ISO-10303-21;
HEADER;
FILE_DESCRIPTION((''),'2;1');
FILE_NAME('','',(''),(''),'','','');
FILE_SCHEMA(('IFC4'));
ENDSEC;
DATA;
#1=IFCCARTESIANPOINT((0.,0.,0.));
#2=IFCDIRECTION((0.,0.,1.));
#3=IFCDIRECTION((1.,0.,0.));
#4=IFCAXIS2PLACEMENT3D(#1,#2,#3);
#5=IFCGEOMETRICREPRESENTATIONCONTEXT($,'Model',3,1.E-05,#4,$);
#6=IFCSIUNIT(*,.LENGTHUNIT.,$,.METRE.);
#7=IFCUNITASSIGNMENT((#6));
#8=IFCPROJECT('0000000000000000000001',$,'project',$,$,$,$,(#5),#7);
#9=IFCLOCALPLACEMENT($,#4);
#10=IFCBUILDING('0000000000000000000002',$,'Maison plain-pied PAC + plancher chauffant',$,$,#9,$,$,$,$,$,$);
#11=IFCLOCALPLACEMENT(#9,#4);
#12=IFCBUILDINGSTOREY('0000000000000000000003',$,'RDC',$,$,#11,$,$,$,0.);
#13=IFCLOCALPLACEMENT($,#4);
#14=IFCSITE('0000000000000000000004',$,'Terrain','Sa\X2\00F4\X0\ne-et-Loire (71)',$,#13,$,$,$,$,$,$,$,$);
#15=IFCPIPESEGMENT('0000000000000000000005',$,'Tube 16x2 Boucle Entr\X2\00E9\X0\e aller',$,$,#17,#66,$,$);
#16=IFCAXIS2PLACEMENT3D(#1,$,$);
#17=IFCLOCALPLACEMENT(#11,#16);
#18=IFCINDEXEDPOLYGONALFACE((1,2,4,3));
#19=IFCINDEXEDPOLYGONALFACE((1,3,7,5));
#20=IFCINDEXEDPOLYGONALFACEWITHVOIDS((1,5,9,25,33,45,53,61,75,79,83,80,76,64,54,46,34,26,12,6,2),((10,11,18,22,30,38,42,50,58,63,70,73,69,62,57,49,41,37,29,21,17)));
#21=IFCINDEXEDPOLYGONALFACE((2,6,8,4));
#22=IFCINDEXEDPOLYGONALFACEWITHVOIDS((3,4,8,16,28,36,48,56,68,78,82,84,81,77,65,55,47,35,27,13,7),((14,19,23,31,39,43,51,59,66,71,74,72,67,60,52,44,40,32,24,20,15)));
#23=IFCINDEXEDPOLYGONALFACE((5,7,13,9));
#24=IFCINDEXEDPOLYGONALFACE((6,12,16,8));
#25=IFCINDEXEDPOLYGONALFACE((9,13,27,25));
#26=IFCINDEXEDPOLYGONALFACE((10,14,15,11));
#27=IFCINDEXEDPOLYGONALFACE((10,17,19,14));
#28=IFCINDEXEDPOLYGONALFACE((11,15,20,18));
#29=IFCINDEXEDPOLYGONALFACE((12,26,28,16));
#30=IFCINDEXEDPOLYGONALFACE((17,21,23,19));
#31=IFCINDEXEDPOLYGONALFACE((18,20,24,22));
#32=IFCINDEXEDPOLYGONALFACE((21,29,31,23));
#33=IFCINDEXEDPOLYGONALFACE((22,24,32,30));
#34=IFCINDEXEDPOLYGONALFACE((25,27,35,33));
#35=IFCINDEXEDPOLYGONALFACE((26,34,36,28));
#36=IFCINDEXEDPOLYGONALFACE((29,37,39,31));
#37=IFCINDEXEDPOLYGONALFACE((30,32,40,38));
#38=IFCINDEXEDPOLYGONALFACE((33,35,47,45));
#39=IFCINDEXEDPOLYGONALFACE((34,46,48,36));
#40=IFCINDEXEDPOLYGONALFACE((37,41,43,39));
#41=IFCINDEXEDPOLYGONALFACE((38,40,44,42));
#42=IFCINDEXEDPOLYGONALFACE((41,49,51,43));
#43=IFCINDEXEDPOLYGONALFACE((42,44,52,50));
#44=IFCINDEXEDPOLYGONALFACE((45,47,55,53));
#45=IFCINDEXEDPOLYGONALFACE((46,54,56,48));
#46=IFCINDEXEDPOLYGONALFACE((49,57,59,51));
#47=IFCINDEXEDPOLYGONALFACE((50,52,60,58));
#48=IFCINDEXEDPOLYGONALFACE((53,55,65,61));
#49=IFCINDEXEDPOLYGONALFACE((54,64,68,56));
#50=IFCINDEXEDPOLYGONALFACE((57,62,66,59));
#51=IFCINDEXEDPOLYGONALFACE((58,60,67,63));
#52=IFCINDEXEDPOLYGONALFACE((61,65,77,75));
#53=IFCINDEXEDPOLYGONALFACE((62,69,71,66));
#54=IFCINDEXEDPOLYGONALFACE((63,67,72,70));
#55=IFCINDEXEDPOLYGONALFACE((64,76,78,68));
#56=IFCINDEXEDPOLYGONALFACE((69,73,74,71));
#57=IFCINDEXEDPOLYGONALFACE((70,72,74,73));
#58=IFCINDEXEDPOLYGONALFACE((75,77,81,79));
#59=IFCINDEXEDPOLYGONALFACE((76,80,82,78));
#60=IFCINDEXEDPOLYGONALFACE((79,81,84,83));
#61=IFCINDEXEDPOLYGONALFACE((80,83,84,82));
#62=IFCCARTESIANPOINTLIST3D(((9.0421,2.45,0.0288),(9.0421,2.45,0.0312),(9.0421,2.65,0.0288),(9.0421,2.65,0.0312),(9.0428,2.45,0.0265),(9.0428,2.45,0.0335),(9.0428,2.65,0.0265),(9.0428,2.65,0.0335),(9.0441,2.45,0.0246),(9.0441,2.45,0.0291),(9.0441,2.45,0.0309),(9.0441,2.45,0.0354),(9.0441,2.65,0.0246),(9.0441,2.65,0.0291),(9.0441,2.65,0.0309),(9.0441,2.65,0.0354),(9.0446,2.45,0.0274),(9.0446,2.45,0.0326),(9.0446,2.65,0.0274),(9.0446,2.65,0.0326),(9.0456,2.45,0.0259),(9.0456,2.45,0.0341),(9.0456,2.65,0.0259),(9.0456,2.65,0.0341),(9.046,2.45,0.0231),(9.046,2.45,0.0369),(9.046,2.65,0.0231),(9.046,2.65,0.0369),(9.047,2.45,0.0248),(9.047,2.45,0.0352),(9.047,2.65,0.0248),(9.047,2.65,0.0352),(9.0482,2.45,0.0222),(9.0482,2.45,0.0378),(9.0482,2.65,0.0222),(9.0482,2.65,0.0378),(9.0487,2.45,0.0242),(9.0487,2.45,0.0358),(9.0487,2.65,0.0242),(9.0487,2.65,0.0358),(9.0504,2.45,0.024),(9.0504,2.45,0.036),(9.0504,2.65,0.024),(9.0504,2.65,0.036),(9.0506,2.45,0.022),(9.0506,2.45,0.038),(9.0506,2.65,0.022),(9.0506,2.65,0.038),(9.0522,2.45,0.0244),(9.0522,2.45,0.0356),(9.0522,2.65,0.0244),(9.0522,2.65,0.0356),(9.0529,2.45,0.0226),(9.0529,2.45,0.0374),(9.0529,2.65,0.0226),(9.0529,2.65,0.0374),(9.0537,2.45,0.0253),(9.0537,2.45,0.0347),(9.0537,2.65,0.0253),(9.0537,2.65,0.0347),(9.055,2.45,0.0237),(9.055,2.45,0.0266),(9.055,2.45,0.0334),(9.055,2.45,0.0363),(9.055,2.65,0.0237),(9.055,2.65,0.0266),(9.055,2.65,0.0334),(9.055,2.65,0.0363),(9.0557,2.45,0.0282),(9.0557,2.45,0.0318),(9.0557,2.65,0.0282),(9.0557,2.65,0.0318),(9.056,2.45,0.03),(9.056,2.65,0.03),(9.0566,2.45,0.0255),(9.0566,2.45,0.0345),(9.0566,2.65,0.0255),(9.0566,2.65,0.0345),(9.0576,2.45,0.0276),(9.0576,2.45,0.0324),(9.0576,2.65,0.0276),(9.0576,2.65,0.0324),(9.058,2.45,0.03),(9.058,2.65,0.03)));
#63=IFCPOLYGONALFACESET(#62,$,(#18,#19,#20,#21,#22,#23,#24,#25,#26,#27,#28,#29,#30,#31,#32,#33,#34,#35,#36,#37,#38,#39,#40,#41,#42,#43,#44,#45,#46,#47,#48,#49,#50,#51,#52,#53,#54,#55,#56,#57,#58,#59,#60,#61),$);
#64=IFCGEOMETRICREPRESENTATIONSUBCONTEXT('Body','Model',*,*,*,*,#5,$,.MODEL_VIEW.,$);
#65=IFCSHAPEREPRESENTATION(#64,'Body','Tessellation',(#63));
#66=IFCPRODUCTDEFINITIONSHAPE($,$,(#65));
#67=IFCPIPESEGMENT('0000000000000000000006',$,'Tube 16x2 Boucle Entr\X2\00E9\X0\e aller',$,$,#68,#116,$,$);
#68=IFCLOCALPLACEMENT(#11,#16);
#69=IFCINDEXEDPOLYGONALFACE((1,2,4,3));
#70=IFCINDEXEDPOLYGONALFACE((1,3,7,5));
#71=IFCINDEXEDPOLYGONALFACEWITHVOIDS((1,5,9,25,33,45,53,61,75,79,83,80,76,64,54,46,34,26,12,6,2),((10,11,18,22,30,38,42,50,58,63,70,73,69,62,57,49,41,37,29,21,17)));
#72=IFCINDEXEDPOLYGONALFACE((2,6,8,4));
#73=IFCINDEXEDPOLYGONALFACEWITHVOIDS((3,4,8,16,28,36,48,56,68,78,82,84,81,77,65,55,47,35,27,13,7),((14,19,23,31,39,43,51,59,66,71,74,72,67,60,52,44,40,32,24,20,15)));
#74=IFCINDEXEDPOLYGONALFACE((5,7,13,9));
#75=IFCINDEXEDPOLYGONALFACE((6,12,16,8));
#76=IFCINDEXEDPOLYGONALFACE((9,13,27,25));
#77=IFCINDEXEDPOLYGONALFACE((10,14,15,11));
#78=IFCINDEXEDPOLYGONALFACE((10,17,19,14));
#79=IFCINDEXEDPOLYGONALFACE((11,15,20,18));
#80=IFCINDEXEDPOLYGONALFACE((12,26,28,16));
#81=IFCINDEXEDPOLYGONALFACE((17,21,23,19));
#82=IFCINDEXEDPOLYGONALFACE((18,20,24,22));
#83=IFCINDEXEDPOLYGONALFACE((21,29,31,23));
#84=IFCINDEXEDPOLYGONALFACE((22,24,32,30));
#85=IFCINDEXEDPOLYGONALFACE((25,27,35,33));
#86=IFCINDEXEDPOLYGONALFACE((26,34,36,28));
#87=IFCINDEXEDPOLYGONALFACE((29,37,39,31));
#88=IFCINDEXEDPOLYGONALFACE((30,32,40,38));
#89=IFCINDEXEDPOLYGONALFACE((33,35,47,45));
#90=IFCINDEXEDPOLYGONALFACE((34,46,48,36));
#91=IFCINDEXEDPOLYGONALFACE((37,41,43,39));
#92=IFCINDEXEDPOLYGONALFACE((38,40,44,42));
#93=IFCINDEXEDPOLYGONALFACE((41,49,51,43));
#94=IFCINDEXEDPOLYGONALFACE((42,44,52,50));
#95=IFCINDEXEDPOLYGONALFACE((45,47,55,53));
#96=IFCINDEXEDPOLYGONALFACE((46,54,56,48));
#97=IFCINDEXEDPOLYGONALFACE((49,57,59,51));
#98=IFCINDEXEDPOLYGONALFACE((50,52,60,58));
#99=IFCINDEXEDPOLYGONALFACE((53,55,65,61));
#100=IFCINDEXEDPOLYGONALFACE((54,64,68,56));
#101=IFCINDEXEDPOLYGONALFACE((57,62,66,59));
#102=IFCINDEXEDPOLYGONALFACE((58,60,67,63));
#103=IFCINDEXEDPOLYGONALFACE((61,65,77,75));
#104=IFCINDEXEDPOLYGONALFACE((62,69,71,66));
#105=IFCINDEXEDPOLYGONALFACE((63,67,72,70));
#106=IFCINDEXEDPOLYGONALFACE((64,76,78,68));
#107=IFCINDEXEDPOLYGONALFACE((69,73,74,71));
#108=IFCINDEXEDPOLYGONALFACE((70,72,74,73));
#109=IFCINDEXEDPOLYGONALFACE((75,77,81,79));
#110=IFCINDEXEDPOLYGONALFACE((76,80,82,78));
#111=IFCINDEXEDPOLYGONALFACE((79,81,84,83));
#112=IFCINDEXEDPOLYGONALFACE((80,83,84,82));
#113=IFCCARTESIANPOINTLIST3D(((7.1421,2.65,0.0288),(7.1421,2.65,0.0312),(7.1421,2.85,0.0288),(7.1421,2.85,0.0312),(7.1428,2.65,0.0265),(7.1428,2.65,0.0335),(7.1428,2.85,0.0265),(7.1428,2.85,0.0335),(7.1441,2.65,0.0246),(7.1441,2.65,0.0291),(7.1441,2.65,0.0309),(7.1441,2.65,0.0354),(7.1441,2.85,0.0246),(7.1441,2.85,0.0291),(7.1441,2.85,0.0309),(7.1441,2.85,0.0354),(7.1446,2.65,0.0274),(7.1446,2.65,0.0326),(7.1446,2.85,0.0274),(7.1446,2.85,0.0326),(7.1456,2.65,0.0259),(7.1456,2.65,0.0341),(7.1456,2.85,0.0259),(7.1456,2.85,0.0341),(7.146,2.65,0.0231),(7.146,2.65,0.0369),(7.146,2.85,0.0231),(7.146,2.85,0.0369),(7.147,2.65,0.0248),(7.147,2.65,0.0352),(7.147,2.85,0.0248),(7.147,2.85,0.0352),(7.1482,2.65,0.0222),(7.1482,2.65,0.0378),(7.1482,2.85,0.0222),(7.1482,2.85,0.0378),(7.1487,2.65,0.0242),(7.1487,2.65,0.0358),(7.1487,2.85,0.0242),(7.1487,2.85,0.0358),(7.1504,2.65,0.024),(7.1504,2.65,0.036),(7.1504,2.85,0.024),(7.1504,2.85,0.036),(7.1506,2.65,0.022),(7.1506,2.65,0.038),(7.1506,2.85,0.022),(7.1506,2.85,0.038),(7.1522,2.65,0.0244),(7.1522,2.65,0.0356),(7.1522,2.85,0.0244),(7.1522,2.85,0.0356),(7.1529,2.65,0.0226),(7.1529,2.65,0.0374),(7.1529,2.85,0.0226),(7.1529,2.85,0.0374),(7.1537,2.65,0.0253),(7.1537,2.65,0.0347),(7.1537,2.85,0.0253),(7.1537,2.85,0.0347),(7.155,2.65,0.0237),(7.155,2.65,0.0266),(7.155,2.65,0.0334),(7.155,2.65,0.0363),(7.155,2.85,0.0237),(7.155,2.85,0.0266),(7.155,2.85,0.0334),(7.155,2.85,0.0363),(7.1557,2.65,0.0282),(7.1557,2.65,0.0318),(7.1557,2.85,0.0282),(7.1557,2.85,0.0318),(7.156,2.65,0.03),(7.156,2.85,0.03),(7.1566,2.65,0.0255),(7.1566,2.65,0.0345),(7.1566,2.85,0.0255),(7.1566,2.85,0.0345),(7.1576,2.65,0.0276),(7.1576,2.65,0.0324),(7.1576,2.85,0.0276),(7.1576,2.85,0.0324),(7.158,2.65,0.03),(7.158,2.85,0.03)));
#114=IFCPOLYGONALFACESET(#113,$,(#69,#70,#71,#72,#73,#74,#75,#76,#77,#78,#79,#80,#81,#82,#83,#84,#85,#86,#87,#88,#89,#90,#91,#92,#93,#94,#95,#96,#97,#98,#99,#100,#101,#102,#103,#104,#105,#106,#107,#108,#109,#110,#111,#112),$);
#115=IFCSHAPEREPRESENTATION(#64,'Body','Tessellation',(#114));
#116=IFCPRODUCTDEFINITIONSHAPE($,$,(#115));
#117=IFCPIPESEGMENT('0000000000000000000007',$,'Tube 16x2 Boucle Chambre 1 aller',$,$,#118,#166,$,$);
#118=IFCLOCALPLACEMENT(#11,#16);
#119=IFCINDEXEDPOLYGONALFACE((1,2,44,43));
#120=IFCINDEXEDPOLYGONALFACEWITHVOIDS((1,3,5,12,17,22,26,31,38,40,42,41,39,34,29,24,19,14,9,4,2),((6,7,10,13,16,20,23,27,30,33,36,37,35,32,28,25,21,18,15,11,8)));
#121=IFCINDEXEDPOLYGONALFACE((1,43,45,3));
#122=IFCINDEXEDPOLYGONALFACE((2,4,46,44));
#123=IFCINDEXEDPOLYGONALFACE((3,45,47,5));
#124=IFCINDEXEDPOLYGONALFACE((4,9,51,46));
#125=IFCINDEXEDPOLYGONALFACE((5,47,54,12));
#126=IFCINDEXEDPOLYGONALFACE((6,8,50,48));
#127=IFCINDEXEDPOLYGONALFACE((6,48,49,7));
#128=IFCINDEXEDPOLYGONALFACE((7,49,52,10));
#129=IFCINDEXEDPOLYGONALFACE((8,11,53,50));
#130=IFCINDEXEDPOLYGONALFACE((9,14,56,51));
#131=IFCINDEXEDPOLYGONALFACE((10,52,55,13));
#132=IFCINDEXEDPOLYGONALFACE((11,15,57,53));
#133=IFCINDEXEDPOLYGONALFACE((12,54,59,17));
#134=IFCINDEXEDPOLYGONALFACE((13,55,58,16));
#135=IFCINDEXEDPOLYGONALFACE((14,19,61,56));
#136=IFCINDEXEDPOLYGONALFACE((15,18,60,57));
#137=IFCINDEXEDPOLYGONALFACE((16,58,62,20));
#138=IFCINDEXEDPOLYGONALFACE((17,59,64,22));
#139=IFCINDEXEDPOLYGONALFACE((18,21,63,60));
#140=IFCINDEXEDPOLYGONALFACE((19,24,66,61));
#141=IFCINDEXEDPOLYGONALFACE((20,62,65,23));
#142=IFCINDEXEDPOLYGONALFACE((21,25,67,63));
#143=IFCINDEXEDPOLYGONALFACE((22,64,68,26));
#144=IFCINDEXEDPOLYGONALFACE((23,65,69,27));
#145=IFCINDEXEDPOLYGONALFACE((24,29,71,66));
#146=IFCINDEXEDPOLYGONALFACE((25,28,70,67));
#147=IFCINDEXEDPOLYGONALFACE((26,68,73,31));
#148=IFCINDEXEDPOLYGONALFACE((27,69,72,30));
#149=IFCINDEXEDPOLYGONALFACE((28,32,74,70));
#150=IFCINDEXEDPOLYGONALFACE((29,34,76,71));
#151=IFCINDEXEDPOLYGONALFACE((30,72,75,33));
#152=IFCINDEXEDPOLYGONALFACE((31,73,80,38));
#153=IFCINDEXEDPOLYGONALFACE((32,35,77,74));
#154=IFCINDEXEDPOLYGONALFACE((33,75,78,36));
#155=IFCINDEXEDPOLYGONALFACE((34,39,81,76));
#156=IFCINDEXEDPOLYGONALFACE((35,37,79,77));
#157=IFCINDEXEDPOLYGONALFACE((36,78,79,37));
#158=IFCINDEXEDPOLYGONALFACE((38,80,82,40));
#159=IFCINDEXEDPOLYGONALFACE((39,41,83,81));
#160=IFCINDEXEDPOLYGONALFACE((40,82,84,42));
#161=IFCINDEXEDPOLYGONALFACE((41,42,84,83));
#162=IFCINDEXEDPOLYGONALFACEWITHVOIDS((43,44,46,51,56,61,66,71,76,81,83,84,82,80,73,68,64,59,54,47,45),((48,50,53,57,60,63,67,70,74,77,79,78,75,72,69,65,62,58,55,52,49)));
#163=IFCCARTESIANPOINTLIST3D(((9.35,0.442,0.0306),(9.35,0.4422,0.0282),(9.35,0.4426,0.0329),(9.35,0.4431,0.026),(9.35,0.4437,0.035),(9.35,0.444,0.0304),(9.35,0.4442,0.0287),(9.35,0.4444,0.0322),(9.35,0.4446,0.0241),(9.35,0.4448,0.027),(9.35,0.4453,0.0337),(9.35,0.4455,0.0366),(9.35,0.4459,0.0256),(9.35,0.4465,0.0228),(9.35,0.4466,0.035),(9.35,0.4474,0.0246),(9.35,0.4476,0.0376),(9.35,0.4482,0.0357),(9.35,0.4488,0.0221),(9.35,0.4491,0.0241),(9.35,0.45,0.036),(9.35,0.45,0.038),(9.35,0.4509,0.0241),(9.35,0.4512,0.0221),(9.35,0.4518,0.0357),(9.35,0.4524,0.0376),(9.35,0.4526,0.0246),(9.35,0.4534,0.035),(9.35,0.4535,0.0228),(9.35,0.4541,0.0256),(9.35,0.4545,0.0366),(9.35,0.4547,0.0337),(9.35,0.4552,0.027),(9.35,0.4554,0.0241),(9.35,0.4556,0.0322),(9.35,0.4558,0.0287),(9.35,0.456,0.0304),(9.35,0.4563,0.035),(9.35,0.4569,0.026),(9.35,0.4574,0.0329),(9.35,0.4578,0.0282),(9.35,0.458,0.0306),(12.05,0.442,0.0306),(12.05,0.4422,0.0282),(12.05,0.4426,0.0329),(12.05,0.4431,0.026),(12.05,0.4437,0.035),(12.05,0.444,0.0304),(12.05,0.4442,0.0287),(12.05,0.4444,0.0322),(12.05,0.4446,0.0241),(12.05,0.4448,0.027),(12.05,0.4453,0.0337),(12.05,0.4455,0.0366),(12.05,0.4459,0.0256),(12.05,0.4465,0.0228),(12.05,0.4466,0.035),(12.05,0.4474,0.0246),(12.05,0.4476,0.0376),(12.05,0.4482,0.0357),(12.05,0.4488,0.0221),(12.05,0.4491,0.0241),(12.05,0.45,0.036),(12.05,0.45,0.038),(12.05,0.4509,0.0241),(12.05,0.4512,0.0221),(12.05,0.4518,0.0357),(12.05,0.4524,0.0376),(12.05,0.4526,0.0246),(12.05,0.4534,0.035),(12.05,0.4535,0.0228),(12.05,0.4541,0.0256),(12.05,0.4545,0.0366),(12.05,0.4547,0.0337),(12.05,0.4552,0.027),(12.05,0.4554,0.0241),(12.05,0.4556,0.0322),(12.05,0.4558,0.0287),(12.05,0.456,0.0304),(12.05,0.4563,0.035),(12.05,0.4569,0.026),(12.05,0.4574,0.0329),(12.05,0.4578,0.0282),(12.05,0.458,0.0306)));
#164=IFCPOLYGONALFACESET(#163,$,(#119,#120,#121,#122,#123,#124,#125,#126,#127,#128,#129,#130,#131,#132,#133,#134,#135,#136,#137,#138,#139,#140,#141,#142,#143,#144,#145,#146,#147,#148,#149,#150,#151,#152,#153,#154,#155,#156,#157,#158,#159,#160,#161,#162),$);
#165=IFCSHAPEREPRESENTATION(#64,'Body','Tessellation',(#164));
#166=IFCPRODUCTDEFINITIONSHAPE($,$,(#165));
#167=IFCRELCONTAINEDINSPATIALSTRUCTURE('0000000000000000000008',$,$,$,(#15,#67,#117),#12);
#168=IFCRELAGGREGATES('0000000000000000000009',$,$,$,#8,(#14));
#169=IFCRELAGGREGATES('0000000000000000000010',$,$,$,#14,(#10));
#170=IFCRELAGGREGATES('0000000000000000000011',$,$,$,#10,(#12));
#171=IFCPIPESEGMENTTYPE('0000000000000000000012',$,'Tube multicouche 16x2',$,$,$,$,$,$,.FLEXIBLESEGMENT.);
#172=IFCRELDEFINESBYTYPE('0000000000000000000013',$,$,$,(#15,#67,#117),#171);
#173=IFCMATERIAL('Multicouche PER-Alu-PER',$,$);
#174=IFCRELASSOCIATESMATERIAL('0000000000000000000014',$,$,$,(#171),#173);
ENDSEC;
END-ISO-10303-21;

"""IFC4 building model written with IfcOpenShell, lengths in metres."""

from ifc_helpers import new_model, si_unit, frame, origin_with_axes, place, context, subcontext, project, spatial, hollow_circle, extrude, material, type_object, element, save


model = new_model("IFC4")

# Units and contexts
model_context = context("Model", 3, precision=1e-05, world=origin_with_axes())
body_context = subcontext(model_context, "Body", "Model", "MODEL_VIEW")
ifc_project = project(units=[si_unit("LENGTHUNIT", "METRE")], contexts=[model_context])

# Site, building, storey
site_placement = place(None, origin_with_axes())
site = spatial("IfcSite", under=ifc_project, at=site_placement, Name="Terrain", Description="Saône-et-Loire (71)")
building_placement = place(None, origin_with_axes())
building = spatial("IfcBuilding", under=site, at=building_placement, Name="Maison plain-pied PAC + plancher chauffant")
storey_placement = place(building_placement, origin_with_axes())
storey = spatial("IfcBuildingStorey", under=building, at=storey_placement, Name="RDC", Elevation=0.0)

# Pipe segments
ifc_material_1 = material(Name="Multicouche PER-Alu-PER")
pipe_segment_type = type_object("IfcPipeSegmentType", Name="Tube multicouche 16x2", PredefinedType="FLEXIBLESEGMENT", material=ifc_material_1)
pipe_segment_1_placement = place(storey_placement, frame((9.05, 2.45, 0.03), z_axis=(0.0, 1.0, 0.0), x_axis=(1.0, 0.0, 0.0)))
element("IfcPipeSegment", 1, at=pipe_segment_1_placement, inside=storey, type_object=pipe_segment_type, Name="Tube 16x2 Boucle Entrée aller", context=body_context, shape_type="SweptSolid", body=[
    extrude(hollow_circle(Radius=0.008, WallThickness=0.002), origin_with_axes(), (0.0, 0.0, 1.0), 0.2),
])
pipe_segment_2_placement = place(storey_placement, frame((7.15, 2.65, 0.03), z_axis=(0.0, 1.0, 0.0), x_axis=(1.0, 0.0, 0.0)))
element("IfcPipeSegment", 2, at=pipe_segment_2_placement, inside=storey, type_object=pipe_segment_type, Name="Tube 16x2 Boucle Entrée aller", context=body_context, shape_type="SweptSolid", body=[
    extrude(hollow_circle(Radius=0.008, WallThickness=0.002), origin_with_axes(), (0.0, 0.0, 1.0), 0.2),
])
pipe_segment_3_placement = place(storey_placement, frame((9.35, 0.45, 0.03), z_axis=(1.0, 0.0, 0.0), x_axis=(0.0, 0.0, 1.0)))
element("IfcPipeSegment", 3, at=pipe_segment_3_placement, inside=storey, type_object=pipe_segment_type, Name="Tube 16x2 Boucle Chambre 1 aller", context=body_context, shape_type="SweptSolid", body=[
    extrude(hollow_circle(Radius=0.008, WallThickness=0.002), origin_with_axes(), (0.0, 0.0, 1.0), 2.7),
])

save(model, "model.ifc")
